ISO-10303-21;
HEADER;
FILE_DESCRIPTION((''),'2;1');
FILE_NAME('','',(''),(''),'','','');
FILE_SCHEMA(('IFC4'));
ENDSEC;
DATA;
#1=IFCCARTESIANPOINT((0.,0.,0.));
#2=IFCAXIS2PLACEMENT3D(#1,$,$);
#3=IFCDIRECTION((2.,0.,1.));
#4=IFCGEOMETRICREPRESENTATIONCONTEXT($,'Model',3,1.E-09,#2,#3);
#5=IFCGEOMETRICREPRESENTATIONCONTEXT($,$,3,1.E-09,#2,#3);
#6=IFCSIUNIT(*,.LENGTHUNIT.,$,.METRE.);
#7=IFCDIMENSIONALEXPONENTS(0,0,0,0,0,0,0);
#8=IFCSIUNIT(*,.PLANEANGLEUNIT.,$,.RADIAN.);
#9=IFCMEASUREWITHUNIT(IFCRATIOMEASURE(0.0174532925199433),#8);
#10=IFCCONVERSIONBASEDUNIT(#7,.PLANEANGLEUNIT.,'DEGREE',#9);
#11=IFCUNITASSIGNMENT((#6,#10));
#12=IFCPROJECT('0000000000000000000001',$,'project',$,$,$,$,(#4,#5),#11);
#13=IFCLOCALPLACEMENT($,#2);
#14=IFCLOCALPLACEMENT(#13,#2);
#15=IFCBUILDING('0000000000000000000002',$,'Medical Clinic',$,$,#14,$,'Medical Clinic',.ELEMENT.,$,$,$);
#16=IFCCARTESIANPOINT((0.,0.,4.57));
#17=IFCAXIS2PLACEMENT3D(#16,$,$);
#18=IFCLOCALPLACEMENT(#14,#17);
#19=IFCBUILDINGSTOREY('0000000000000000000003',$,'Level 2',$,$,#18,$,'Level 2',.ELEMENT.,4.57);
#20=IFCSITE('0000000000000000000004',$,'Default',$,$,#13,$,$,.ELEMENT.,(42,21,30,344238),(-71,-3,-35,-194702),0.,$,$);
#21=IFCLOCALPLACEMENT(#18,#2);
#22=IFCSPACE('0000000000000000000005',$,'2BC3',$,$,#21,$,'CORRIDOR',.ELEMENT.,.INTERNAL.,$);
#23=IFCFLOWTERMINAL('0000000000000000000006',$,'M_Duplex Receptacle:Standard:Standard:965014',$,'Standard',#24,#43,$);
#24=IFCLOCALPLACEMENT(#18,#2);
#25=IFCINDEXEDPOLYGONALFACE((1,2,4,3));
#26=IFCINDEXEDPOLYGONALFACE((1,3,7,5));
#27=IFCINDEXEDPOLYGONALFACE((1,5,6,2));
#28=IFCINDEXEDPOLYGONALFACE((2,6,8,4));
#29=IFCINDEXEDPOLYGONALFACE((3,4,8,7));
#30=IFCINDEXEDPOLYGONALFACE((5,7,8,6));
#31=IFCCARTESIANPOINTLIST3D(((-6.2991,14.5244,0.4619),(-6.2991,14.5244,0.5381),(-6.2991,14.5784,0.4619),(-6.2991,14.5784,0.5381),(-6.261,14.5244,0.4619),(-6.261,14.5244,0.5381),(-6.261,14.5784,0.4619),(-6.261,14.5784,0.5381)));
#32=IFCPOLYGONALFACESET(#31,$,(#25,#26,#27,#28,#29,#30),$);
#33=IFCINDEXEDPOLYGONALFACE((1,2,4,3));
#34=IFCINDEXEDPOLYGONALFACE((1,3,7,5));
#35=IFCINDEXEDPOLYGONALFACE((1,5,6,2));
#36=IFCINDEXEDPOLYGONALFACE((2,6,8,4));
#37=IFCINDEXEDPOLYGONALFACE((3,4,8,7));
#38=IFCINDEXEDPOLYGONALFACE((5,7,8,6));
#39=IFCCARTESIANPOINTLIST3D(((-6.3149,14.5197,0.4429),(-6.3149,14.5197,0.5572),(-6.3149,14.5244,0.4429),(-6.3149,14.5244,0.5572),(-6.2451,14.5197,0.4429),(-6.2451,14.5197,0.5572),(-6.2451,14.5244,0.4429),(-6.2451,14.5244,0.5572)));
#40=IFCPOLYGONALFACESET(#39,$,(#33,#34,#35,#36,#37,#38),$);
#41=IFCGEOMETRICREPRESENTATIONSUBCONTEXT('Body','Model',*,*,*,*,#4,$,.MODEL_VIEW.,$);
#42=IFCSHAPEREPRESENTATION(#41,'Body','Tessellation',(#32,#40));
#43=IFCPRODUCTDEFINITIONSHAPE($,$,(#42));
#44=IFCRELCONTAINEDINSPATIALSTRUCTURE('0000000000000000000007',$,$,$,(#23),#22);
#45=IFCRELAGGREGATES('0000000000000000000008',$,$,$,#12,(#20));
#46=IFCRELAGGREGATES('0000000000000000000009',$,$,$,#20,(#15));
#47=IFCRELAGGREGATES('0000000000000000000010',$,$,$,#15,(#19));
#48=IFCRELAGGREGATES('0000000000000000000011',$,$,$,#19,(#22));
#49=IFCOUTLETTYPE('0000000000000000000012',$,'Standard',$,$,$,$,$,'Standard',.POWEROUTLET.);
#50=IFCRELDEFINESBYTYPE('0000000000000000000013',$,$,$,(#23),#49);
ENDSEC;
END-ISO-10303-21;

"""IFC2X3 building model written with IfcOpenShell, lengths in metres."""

from ifc_helpers import new_model, entity, si_unit, converted_unit, direction, frame, frame_2d, origin, origin_2d_with_axis, place, context, subcontext, project, spatial, rectangle, extrude, source, transform, mapped, type_object, type_shapes, element, save


model = new_model("IFC2X3")

# Units and contexts
model_context = context("Model", 3, precision=1e-09, world=origin(), true_north=direction((2.0, 0.0, 1.0)))
context_of_model = context(None, 3, precision=1e-09, world=origin(), true_north=direction((2.0, 0.0, 1.0)))
body_context = subcontext(model_context, "Body", "Model", "MODEL_VIEW")
ifc_project = project(units=[si_unit("LENGTHUNIT", "METRE"), converted_unit("PLANEANGLEUNIT", "DEGREE", entity("IfcRatioMeasure", 0.0174532925199433), si_unit("PLANEANGLEUNIT", "RADIAN"), dimensions=[0, 0, 0, 0, 0, 0, 0])], contexts=[model_context, context_of_model])

# Site, building, storey, space
site_placement = place(None, origin())
site = spatial("IfcSite", under=ifc_project, at=site_placement, Name="Default", CompositionType="ELEMENT", RefLatitude=(42, 21, 30, 344238), RefLongitude=(-71, -3, -35, -194702), RefElevation=0.0)
building_placement = place(site_placement, origin())
building = spatial("IfcBuilding", under=site, at=building_placement, Name="Medical Clinic", LongName="Medical Clinic", CompositionType="ELEMENT")
storey_placement = place(building_placement, frame((0.0, 0.0, 4.57)))
storey = spatial("IfcBuildingStorey", under=building, at=storey_placement, Name="Level 2", LongName="Level 2", CompositionType="ELEMENT", Elevation=4.57)
space_1_placement = place(storey_placement, origin())
space_1 = spatial("IfcSpace", under=storey, at=space_1_placement, Name="2BC3", LongName="CORRIDOR", CompositionType="ELEMENT", InteriorOrExteriorSpace="INTERNAL")

# Shared definitions
outlet_type = type_object("IfcOutletType", Name="Standard", ElementType="Standard", PredefinedType="POWEROUTLET")
shared_shape_1 = source(origin(), body_context, "Body", "SweptSolid", [
    extrude(rectangle(XDim=0.0381, YDim=0.0762, at=origin_2d_with_axis()), frame((0.0, 0.0, -0.054), z_axis=(0.0, 0.0, 1.0), x_axis=(-1.0, 0.0, 0.0)), (0.0, 0.0, 1.0), 0.054),
    extrude(rectangle(XDim=0.0698, YDim=0.1143, at=frame_2d((0.0, 0.0), x_axis=(1.0, 0.0))), frame((0.0, 0.0, 0.0), z_axis=(0.0, 0.0, 1.0), x_axis=(-1.0, 0.0, 0.0)), (0.0, 0.0, 1.0), 0.0048),
])
type_shapes(outlet_type, [shared_shape_1])

# Flow terminal
flow_terminal_1_placement = place(space_1_placement, frame((-6.28, 14.5244, 0.5), z_axis=(0.0, -1.0, 0.0), x_axis=(1.0, 0.0, 0.0)))
element("IfcFlowTerminal", 1, at=flow_terminal_1_placement, inside=space_1, type_object=outlet_type, Name="M_Duplex Receptacle:Standard:Standard:965014", ObjectType="Standard", context=body_context, shape_type="MappedRepresentation", body=[
    mapped(shared_shape_1, transform((0.0, 0.0, 0.0), scale=1.0)),
])

save(model, "model.ifc")
